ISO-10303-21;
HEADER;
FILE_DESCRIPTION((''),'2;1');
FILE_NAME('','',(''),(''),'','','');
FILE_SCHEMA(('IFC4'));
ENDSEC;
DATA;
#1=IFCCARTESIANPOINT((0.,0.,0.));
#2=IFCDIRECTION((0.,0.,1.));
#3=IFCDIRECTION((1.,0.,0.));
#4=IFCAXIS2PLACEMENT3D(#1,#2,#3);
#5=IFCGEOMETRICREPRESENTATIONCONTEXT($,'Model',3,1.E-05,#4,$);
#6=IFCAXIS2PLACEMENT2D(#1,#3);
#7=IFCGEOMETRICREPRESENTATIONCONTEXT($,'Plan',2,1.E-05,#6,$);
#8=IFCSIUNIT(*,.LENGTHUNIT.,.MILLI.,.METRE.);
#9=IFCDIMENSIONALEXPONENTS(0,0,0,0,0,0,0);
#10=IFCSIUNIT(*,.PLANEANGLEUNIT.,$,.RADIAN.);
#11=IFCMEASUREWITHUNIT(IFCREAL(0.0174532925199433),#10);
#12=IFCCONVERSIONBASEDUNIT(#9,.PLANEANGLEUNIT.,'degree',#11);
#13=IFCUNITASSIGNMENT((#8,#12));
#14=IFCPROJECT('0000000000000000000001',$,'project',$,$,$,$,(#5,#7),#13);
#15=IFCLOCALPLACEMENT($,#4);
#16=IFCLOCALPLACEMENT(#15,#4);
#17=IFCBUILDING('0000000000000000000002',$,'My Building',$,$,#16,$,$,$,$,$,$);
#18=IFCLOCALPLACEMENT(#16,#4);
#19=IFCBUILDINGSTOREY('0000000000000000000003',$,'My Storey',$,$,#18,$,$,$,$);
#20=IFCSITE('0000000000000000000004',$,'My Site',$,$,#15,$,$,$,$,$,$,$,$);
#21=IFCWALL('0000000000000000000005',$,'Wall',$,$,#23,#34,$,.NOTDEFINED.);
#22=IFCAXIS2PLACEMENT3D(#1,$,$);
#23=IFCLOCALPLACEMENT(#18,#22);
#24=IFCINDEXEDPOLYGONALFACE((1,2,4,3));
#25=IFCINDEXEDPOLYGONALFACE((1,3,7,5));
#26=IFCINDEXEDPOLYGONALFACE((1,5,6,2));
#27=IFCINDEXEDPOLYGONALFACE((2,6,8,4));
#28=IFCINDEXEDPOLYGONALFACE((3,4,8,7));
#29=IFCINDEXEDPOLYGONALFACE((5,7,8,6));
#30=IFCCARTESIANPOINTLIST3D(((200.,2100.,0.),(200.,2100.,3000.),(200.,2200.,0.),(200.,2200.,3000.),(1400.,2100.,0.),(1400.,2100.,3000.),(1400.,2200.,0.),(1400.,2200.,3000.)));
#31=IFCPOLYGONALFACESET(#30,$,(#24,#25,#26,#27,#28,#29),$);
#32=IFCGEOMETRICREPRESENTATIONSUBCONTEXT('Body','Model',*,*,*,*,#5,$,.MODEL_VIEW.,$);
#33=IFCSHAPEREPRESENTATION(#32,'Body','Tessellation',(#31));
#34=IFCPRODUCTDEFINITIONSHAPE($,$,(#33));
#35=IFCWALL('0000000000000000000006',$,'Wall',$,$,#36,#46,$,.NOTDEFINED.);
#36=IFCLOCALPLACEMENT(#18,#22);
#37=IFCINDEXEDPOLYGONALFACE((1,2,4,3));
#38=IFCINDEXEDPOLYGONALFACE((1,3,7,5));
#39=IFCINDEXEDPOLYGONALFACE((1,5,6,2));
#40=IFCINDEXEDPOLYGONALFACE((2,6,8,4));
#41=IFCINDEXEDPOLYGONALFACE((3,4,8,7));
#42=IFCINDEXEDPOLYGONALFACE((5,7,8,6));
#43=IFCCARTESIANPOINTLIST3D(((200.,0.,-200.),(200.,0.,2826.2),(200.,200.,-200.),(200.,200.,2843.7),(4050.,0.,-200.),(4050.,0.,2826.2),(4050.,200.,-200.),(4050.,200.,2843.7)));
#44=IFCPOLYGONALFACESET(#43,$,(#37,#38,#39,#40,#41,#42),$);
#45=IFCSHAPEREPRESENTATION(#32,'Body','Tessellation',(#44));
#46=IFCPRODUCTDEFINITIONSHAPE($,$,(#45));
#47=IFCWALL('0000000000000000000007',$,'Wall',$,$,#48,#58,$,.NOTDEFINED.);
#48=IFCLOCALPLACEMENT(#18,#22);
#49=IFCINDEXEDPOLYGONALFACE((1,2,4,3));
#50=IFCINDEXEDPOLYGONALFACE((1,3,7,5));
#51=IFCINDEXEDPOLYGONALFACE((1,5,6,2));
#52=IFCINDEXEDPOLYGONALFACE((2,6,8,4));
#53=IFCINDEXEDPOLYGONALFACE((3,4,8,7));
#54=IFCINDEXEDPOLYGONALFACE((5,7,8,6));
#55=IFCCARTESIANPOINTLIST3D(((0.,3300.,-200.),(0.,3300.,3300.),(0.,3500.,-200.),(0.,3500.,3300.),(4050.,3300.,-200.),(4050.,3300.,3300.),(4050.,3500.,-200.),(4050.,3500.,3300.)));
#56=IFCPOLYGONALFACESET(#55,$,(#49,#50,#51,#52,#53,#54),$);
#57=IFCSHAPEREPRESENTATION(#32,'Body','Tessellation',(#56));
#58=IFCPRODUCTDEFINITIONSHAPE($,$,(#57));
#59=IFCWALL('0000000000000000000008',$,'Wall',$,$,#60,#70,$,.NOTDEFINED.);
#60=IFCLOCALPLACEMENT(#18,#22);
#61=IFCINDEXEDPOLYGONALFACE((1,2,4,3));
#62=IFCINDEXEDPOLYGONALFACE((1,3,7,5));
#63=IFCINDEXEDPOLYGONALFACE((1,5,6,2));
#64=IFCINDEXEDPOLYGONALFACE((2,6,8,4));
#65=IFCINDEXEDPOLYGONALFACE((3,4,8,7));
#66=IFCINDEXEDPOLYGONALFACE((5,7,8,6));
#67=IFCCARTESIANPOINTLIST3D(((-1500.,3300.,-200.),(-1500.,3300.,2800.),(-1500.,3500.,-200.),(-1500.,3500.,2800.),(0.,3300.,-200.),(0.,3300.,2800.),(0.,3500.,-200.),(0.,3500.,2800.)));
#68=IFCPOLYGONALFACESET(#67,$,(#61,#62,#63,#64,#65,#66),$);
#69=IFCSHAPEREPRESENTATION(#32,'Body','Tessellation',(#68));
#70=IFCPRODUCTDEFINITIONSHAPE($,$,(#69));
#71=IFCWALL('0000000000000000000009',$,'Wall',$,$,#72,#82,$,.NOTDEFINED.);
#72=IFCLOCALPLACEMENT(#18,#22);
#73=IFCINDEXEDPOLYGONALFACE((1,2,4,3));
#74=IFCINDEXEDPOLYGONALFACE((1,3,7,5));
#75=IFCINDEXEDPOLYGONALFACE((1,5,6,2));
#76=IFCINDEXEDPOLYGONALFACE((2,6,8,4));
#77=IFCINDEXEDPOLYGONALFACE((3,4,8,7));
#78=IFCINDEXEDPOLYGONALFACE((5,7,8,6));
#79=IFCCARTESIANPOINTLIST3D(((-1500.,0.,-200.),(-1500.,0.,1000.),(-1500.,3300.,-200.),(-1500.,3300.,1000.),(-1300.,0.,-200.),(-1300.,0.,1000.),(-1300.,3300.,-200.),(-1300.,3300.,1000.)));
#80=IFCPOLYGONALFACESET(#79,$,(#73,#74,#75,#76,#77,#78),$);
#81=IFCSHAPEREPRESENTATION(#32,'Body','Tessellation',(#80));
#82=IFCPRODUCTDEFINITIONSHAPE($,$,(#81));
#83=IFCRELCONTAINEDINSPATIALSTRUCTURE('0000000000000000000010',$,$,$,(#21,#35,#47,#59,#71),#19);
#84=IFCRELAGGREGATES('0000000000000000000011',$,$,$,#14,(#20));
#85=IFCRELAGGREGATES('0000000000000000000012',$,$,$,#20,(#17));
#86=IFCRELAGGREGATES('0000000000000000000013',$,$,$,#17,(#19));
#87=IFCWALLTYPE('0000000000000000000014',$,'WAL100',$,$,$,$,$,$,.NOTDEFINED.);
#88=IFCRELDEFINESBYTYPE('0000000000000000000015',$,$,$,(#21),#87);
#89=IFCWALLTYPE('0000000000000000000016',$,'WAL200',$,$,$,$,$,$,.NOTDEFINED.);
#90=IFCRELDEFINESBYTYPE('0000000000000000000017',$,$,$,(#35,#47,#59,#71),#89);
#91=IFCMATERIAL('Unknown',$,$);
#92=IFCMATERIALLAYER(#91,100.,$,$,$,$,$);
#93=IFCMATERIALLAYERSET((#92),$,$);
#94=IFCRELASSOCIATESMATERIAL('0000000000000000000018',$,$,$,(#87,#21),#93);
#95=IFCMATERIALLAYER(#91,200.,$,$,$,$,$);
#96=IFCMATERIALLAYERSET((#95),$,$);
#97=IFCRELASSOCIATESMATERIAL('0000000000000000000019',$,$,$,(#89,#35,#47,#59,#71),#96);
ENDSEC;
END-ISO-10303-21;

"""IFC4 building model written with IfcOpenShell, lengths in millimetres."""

from ifc_helpers import new_model, entity, si_unit, converted_unit, frame, frame_2d, origin_with_axes, place, context, subcontext, project, spatial, indexed_curve, outline, extrude, clip, halfspace, material, layer, layer_set, layer_usage, type_object, element, save


model = new_model("IFC4")

# Units and contexts
model_context = context("Model", 3, precision=1e-05, world=origin_with_axes())
plan_context = context("Plan", 2, precision=1e-05, world=frame_2d((0.0, 0.0, 0.0), x_axis=(1.0, 0.0, 0.0)))
body_context = subcontext(model_context, "Body", "Model", "MODEL_VIEW")
ifc_project = project(units=[si_unit("LENGTHUNIT", "METRE", prefix="MILLI"), converted_unit("PLANEANGLEUNIT", "degree", entity("IfcReal", 0.0174532925199433), si_unit("PLANEANGLEUNIT", "RADIAN"), dimensions=[0, 0, 0, 0, 0, 0, 0])], contexts=[model_context, plan_context])

# Site, building, storey
site_placement = place(None, origin_with_axes())
site = spatial("IfcSite", under=ifc_project, at=site_placement, Name="My Site")
building_placement = place(site_placement, origin_with_axes())
building = spatial("IfcBuilding", under=site, at=building_placement, Name="My Building")
storey_placement = place(building_placement, origin_with_axes())
storey = spatial("IfcBuildingStorey", under=building, at=storey_placement, Name="My Storey")

# Shared definitions
ifc_material = material(Name="Unknown")

# Walls
ifc_layer_1 = layer(ifc_material, 100.0)
ifc_layer_set_1 = layer_set([ifc_layer_1])
ifc_layer_usage_1 = layer_usage(ifc_layer_set_1, "AXIS2", "POSITIVE", 0.0)
wall_type_1 = type_object("IfcWallType", Name="WAL100", PredefinedType="NOTDEFINED", material=ifc_layer_set_1)
wall_1_placement = place(storey_placement, frame((200.0, 2100.0, 0.0), z_axis=(0.0, 0.0, 1.0), x_axis=(1.0, 0.0, 0.0)))
element("IfcWall", 1, at=wall_1_placement, inside=storey, type_object=wall_type_1, material=ifc_layer_usage_1, Name="Wall", PredefinedType="NOTDEFINED", context=body_context, shape_type="SweptSolid", body=[
    extrude(outline(indexed_curve([(0.0, 0.0), (0.0, 100.0), (1200.0, 100.0), (1200.0, 0.0), (0.0, 0.0)], self_intersect=False)), origin_with_axes(), (0.0, 0.0, 1.0), 3000.0),
])
ifc_layer_2 = layer(ifc_material, 200.0)
ifc_layer_set_2 = layer_set([ifc_layer_2])
ifc_layer_usage_2 = layer_usage(ifc_layer_set_2, "AXIS2", "POSITIVE", 0.0)
wall_type_2 = type_object("IfcWallType", Name="WAL200", PredefinedType="NOTDEFINED", material=ifc_layer_set_2)
wall_2_placement = place(storey_placement, frame((200.0, 0.0, -200.0), z_axis=(0.0, 0.0, 1.0), x_axis=(1.0, 0.0, 0.0)))
element("IfcWall", 2, at=wall_2_placement, inside=storey, type_object=wall_type_2, material=ifc_layer_usage_2, Name="Wall", PredefinedType="NOTDEFINED", context=body_context, shape_type="Clipping", body=[
    clip(extrude(outline(indexed_curve([(0.0, 0.0), (0.0, 200.0), (3850.0, 200.0), (3850.0, 0.0), (0.0, 0.0)], self_intersect=False)), origin_with_axes(), (0.0, 0.0, 1.0), 3043.7), halfspace(frame((0.0, 200.0, 3043.7), z_axis=(0.0, -0.087156, 0.996195), x_axis=(1.0, 0.0, 0.0)), False)),
])
ifc_layer_usage_3 = layer_usage(ifc_layer_set_2, "AXIS2", "POSITIVE", 0.0)
wall_3_placement = place(storey_placement, frame((4050.0, 3500.0, -200.0), z_axis=(0.0, 0.0, 1.0), x_axis=(-1.0, 0.0, 0.0)))
element("IfcWall", 3, at=wall_3_placement, inside=storey, type_object=wall_type_2, material=ifc_layer_usage_3, Name="Wall", PredefinedType="NOTDEFINED", context=body_context, shape_type="SweptSolid", body=[
    extrude(outline(indexed_curve([(0.0, 0.0), (0.0, 200.0), (4050.0, 200.0), (4050.0, 0.0), (0.0, 0.0)], self_intersect=False)), origin_with_axes(), (0.0, 0.0, 1.0), 3500.0),
])
ifc_layer_usage_4 = layer_usage(ifc_layer_set_2, "AXIS2", "POSITIVE", 0.0)
wall_4_placement = place(storey_placement, frame((0.0, 3500.0, -200.0), z_axis=(0.0, 0.0, 1.0), x_axis=(-1.0, 0.0, 0.0)))
element("IfcWall", 4, at=wall_4_placement, inside=storey, type_object=wall_type_2, material=ifc_layer_usage_4, Name="Wall", PredefinedType="NOTDEFINED", context=body_context, shape_type="SweptSolid", body=[
    extrude(outline(indexed_curve([(0.0, 0.0), (0.0, 200.0), (1500.0, 200.0), (1500.0, 0.0), (0.0, 0.0)], self_intersect=False)), origin_with_axes(), (0.0, 0.0, 1.0), 3000.0),
])
ifc_layer_usage_5 = layer_usage(ifc_layer_set_2, "AXIS2", "POSITIVE", 0.0)
wall_5_placement = place(storey_placement, frame((-1500.0, 3300.0, -200.0), z_axis=(0.0, 0.0, 1.0), x_axis=(0.0, -1.0, 0.0)))
element("IfcWall", 5, at=wall_5_placement, inside=storey, type_object=wall_type_2, material=ifc_layer_usage_5, Name="Wall", PredefinedType="NOTDEFINED", context=body_context, shape_type="SweptSolid", body=[
    extrude(outline(indexed_curve([(0.0, 0.0), (0.0, 200.0), (3300.0, 200.0), (3300.0, 0.0), (0.0, 0.0)], self_intersect=False)), origin_with_axes(), (0.0, 0.0, 1.0), 1200.0),
])

save(model, "model.ifc")
